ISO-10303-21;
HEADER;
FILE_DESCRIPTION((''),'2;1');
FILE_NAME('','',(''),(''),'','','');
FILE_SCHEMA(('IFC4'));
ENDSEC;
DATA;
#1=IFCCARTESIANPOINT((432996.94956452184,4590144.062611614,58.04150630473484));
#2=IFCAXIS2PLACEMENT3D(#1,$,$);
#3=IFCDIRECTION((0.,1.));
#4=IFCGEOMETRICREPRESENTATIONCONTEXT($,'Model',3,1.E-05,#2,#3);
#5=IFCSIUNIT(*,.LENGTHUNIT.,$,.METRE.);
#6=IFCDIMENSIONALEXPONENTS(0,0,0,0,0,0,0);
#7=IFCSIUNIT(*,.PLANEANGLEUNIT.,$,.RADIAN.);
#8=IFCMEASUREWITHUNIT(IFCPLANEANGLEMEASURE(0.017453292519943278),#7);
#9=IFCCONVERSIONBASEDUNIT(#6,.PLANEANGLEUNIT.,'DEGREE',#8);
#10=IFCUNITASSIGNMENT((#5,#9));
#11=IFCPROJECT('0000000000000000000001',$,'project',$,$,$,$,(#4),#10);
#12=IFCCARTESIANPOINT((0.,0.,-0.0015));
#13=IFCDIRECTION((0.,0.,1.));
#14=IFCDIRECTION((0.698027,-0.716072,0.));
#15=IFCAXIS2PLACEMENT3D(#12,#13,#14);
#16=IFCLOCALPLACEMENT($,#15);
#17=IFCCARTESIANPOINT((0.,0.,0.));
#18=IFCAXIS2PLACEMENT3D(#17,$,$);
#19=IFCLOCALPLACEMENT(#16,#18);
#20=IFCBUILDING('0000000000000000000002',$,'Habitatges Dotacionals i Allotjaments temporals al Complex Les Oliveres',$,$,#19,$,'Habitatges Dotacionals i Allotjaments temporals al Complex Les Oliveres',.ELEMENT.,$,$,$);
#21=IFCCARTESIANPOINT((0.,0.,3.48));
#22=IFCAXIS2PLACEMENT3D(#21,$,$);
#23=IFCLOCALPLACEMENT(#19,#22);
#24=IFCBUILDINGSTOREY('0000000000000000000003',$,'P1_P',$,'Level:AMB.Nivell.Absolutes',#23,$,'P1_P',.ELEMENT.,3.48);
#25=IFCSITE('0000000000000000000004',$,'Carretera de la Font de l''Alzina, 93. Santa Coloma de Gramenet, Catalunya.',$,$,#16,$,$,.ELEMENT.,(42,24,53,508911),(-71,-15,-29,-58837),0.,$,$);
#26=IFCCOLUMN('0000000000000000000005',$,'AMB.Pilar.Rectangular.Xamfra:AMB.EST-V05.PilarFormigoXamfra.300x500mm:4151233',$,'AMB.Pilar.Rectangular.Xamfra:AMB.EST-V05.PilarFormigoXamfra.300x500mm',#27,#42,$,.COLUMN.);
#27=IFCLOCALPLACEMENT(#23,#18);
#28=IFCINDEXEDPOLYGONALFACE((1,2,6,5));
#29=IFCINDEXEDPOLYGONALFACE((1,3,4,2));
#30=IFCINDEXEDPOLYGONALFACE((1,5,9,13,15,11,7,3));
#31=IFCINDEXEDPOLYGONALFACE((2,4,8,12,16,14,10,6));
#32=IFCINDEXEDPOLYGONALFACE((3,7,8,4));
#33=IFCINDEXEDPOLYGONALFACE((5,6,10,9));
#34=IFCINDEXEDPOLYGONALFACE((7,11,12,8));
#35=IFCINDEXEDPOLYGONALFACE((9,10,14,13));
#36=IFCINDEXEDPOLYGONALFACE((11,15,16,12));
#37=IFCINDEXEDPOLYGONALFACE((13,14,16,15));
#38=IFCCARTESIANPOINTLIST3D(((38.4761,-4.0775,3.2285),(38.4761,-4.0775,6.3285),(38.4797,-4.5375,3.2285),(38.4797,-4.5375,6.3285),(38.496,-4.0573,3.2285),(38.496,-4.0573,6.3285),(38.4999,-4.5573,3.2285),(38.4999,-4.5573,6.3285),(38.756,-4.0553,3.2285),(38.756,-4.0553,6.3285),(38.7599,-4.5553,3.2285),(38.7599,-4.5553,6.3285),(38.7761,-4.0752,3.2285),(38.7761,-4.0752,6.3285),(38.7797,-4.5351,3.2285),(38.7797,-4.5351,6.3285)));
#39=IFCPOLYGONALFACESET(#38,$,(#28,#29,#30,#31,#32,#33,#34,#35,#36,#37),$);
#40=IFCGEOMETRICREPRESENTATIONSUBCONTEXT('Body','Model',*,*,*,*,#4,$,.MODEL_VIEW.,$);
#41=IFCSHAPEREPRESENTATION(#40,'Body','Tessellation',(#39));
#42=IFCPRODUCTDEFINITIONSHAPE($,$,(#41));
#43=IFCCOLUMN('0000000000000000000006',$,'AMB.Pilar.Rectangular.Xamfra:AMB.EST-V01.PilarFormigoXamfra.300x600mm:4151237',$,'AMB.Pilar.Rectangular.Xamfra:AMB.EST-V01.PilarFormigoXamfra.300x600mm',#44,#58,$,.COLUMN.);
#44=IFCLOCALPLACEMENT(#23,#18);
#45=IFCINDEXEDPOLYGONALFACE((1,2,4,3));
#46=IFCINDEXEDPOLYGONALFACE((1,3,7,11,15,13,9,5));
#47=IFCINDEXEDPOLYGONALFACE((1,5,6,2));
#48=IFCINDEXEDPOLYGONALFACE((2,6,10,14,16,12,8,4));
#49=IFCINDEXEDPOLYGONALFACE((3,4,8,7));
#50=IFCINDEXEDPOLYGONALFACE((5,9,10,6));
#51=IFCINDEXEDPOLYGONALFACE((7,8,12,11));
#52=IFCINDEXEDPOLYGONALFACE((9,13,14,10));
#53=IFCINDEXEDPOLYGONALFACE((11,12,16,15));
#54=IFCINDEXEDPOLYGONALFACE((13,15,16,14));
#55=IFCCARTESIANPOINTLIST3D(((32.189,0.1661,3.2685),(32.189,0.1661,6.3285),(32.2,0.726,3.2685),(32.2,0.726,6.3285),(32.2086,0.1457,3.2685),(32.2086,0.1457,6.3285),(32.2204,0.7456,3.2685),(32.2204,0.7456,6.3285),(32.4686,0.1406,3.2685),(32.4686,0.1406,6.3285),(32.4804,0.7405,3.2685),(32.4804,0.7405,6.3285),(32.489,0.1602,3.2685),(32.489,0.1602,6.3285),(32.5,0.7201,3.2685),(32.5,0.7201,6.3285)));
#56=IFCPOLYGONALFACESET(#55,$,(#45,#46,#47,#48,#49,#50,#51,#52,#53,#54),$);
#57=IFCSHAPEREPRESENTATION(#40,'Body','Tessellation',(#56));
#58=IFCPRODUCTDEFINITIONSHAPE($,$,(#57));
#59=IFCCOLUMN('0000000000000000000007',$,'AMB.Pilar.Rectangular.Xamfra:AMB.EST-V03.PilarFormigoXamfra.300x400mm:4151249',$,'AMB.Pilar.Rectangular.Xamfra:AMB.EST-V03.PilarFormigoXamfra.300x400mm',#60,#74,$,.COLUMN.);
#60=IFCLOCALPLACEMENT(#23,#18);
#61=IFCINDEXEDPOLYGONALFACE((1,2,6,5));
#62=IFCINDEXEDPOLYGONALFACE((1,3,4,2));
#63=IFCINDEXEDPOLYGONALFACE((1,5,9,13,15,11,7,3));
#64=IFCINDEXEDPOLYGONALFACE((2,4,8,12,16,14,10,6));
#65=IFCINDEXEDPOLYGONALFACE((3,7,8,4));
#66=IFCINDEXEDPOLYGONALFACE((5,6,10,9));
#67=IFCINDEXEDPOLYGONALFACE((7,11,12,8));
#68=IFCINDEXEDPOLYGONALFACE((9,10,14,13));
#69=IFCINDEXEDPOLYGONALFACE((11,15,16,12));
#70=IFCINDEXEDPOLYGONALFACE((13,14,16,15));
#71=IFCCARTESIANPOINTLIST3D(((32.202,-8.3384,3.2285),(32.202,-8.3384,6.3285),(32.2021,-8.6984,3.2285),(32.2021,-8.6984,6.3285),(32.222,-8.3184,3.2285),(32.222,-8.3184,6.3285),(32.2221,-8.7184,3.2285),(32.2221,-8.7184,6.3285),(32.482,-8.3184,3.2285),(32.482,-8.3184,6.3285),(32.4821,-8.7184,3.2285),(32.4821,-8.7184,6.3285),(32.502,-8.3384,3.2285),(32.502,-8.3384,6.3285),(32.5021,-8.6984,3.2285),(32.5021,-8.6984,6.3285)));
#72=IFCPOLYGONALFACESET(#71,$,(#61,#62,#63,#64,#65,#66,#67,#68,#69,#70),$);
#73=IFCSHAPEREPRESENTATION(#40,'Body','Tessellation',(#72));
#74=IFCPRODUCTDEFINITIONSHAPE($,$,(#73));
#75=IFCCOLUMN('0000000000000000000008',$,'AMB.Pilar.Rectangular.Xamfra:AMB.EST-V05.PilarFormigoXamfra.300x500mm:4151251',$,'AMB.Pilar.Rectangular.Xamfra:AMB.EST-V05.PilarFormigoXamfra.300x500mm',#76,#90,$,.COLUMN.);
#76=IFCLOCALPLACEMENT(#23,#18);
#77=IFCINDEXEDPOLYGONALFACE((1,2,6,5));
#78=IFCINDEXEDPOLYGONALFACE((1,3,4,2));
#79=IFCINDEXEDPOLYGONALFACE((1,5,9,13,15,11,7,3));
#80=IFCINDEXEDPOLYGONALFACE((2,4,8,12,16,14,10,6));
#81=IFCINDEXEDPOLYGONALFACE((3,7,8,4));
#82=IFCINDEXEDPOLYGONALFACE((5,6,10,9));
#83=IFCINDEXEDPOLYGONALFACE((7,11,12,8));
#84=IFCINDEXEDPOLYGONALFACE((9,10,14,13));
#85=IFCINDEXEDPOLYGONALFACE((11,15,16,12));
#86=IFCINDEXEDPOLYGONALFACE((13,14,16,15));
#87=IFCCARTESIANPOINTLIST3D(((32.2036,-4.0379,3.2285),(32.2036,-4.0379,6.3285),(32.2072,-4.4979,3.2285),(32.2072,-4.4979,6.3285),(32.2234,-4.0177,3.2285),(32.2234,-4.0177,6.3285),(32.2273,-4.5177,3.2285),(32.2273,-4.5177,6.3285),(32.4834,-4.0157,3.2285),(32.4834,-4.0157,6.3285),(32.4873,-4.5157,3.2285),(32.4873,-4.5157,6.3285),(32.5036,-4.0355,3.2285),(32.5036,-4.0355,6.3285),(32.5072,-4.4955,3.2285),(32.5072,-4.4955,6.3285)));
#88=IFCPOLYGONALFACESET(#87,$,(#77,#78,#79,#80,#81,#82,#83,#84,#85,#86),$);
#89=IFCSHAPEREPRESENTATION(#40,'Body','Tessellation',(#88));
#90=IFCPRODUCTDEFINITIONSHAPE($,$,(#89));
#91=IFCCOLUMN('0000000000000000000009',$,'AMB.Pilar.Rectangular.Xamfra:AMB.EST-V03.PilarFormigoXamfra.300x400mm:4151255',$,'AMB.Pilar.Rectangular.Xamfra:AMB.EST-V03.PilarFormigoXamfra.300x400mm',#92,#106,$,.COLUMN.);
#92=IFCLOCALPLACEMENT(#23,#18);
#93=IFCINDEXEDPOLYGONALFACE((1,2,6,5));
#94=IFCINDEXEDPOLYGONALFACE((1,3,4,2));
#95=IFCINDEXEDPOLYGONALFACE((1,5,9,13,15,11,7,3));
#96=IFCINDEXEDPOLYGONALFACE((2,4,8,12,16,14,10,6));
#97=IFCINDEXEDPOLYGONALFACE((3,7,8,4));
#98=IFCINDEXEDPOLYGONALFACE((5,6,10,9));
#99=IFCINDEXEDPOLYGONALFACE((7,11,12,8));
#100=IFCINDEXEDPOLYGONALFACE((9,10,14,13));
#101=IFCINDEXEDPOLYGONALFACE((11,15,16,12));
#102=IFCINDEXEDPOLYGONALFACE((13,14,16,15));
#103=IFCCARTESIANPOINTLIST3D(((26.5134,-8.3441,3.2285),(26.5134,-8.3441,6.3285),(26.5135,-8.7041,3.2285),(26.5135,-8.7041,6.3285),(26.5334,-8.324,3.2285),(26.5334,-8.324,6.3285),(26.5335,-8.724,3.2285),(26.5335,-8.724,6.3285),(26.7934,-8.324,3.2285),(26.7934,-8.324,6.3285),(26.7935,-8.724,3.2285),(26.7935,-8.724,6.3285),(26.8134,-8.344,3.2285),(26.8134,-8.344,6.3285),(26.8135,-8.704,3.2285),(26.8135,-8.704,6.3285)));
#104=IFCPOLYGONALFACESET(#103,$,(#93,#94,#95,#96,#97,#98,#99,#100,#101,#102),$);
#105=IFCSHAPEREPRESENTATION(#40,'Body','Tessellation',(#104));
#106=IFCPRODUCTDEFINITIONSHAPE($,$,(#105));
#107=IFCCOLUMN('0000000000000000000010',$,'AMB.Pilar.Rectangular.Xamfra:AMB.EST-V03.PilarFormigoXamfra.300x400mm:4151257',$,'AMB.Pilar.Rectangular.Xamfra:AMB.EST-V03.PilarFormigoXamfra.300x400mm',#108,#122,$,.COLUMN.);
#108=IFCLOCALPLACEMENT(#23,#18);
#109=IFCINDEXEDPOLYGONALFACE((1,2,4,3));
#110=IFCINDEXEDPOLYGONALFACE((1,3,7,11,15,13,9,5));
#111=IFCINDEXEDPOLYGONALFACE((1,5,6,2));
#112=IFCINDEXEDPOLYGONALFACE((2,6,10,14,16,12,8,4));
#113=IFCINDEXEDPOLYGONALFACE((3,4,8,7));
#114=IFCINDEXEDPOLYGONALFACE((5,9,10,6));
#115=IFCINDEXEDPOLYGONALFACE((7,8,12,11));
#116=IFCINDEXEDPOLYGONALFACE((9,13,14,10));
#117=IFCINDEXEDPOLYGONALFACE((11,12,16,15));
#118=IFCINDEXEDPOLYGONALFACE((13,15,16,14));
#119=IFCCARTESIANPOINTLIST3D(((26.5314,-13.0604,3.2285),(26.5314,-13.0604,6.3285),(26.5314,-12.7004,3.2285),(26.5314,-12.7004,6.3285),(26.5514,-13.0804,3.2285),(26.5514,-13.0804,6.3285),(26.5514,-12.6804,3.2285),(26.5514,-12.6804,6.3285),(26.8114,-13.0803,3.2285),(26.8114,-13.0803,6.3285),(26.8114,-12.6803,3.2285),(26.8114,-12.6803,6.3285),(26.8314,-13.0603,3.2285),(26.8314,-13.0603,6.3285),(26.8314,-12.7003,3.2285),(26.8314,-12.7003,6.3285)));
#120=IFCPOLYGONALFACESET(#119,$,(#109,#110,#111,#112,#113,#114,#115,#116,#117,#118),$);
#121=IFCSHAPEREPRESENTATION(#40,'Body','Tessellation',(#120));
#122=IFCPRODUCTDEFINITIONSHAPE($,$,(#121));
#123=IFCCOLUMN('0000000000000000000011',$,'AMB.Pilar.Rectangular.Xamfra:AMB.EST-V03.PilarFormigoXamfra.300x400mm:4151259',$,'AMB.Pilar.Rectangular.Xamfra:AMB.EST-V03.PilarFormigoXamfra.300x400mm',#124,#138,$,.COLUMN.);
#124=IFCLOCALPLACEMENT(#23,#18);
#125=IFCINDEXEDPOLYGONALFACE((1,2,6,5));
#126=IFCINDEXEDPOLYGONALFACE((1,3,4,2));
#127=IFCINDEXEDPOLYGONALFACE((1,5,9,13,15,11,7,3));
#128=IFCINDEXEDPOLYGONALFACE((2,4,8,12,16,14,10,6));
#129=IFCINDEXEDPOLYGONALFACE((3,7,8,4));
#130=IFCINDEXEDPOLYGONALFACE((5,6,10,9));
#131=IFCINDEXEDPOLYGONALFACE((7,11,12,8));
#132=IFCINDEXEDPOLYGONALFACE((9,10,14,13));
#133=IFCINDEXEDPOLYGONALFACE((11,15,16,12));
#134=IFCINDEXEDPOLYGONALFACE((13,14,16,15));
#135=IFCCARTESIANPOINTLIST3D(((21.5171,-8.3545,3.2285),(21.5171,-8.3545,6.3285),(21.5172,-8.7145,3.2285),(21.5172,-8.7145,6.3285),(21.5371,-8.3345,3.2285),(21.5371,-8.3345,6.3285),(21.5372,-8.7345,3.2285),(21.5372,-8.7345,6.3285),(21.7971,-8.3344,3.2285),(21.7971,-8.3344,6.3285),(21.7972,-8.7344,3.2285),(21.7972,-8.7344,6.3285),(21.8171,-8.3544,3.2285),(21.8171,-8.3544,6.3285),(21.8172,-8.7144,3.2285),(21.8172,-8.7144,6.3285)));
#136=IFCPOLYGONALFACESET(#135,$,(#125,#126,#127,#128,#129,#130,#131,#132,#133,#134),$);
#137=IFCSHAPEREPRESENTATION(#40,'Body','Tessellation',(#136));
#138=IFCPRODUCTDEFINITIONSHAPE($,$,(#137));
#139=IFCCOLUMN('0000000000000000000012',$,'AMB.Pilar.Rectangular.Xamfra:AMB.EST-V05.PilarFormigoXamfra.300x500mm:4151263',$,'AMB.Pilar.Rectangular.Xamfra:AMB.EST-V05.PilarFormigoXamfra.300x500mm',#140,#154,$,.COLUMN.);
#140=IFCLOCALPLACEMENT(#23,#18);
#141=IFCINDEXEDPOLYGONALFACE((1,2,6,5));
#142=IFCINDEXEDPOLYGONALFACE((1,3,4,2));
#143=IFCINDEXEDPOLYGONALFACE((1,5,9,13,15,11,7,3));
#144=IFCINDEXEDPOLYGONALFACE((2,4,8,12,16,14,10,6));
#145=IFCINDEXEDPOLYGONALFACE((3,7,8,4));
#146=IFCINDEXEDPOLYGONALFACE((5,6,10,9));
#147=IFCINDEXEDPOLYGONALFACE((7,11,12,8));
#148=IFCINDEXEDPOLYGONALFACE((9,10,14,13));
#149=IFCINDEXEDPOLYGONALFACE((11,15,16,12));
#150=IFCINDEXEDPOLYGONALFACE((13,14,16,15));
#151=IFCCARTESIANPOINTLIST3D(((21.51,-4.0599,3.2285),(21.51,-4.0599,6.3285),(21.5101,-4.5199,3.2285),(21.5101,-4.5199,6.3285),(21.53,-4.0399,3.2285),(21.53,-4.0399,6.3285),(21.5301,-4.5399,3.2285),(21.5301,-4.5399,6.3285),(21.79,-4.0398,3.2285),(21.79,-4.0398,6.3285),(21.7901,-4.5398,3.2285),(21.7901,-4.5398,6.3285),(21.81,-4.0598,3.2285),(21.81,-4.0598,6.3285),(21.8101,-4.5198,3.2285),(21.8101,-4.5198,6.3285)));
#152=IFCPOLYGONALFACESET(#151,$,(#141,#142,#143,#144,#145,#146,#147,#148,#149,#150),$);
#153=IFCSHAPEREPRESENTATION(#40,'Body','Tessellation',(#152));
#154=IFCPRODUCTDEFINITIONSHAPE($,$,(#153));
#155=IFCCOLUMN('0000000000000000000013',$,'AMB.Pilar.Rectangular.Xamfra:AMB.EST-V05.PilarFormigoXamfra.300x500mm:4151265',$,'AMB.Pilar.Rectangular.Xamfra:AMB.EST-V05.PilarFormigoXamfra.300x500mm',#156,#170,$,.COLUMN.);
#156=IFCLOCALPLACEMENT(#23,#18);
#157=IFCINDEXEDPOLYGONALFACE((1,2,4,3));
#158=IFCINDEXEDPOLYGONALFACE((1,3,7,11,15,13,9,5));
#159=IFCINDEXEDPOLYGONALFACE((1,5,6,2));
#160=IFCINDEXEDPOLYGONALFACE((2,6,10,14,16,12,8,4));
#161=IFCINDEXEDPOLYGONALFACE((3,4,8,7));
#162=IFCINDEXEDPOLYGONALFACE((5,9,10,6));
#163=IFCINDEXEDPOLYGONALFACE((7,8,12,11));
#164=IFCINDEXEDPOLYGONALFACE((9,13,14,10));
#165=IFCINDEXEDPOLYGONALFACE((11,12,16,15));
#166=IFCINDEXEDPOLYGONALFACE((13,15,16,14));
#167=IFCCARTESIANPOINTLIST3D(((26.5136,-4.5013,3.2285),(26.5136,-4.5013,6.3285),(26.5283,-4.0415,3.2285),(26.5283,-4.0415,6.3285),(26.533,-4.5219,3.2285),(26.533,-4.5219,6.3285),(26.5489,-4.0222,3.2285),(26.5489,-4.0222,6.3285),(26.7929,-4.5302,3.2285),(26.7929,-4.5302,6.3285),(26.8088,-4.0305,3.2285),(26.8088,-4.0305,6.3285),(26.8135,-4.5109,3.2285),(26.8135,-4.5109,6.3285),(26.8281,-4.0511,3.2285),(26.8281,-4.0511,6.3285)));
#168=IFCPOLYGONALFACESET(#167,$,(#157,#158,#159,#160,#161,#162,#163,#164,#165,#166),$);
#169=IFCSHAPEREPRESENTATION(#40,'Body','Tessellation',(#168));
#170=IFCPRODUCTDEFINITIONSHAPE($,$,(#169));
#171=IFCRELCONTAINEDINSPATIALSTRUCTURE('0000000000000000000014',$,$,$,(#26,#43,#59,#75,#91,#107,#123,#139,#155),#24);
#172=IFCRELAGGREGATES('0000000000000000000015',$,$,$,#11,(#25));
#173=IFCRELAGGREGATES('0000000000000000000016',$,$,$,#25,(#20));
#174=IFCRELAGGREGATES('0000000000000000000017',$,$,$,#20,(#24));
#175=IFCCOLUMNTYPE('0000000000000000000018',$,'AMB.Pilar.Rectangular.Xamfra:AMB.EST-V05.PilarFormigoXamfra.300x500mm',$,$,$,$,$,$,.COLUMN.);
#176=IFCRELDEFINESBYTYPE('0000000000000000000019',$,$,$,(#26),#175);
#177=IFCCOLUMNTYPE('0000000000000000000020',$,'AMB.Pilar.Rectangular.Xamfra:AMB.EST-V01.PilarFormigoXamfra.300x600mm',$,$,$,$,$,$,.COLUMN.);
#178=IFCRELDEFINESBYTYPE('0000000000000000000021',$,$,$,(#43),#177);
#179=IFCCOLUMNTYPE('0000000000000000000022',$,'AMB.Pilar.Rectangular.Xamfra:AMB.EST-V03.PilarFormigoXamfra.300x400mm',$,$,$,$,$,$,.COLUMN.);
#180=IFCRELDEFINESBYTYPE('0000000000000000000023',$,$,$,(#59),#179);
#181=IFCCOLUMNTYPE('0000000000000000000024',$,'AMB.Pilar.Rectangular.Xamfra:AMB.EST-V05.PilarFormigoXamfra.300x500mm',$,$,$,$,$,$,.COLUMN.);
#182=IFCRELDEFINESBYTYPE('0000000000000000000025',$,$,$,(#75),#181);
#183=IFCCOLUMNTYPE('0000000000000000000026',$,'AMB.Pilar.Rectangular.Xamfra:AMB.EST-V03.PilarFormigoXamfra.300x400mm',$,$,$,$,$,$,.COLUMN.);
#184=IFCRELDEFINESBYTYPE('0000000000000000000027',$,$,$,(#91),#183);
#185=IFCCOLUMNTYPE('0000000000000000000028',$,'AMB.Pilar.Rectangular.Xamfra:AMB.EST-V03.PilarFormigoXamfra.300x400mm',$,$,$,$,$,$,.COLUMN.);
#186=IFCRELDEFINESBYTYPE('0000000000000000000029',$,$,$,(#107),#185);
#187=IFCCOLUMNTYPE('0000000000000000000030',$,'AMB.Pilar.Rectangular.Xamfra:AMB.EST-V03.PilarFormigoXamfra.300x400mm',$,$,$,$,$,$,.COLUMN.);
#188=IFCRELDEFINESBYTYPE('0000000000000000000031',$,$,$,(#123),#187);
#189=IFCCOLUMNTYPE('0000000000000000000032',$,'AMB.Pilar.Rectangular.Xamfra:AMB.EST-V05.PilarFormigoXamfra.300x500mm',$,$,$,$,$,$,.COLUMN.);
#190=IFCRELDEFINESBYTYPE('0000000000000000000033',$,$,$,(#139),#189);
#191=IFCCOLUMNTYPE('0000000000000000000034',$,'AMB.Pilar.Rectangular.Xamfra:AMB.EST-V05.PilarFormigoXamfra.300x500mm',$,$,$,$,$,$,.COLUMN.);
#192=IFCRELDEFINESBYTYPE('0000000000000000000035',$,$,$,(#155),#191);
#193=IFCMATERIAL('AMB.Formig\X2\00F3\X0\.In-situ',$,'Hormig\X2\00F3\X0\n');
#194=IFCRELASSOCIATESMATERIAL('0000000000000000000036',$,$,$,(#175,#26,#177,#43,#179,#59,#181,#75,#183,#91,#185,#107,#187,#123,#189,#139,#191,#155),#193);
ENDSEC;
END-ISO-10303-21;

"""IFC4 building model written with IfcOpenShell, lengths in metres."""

from ifc_helpers import new_model, entity, si_unit, converted_unit, direction, frame, origin, place, context, subcontext, project, spatial, indexed_curve, outline, extrude, source, transform, mapped, material, type_object, type_shapes, element, save


model = new_model("IFC4")

# Units and contexts
model_context = context("Model", 3, precision=1e-05, world=frame((432996.94956452184, 4590144.062611614, 58.04150630473484)), true_north=direction((0.0, 1.0)))
body_context = subcontext(model_context, "Body", "Model", "MODEL_VIEW")
ifc_project = project(units=[si_unit("LENGTHUNIT", "METRE"), converted_unit("PLANEANGLEUNIT", "DEGREE", entity("IfcPlaneAngleMeasure", 0.017453292519943278), si_unit("PLANEANGLEUNIT", "RADIAN"), dimensions=[0, 0, 0, 0, 0, 0, 0])], contexts=[model_context])

# Site, building, storey
site_placement = place(None, frame((0.0, 0.0, -0.0015), z_axis=(0.0, 0.0, 1.0), x_axis=(0.698027, -0.716072, 0.0)))
site = spatial("IfcSite", under=ifc_project, at=site_placement, Name="Carretera de la Font de l'Alzina, 93. Santa Coloma de Gramenet, Catalunya.", CompositionType="ELEMENT", RefLatitude=(42, 24, 53, 508911), RefLongitude=(-71, -15, -29, -58837), RefElevation=0.0)
building_placement = place(site_placement, origin())
building = spatial("IfcBuilding", under=site, at=building_placement, Name="Habitatges Dotacionals i Allotjaments temporals al Complex Les Oliveres", LongName="Habitatges Dotacionals i Allotjaments temporals al Complex Les Oliveres", CompositionType="ELEMENT")
storey_placement = place(building_placement, frame((0.0, 0.0, 3.48)))
storey = spatial("IfcBuildingStorey", under=building, at=storey_placement, Name="P1_P", ObjectType="Level:AMB.Nivell.Absolutes", LongName="P1_P", CompositionType="ELEMENT", Elevation=3.48)

# Columns
ifc_material = material(Name="AMB.Formigó.In-situ", Category="Hormigón")
column_type_1 = type_object("IfcColumnType", Name="AMB.Pilar.Rectangular.Xamfra:AMB.EST-V05.PilarFormigoXamfra.300x500mm", PredefinedType="COLUMN", material=ifc_material)
shared_shape_1 = source(origin(), body_context, "Body", "SweptSolid", [
    extrude(outline(indexed_curve([(-0.13, -0.25), (0.13, -0.25), (0.15, -0.23), (0.15, 0.23), (0.13, 0.25), (-0.13, 0.25), (-0.15, 0.23), (-0.15, -0.23), (-0.13, -0.25)], self_intersect=False)), frame((38.6279, -4.3063, 6.7085), z_axis=(0.0, 0.0, 1.0), x_axis=(-0.99997, -0.007796, 0.0)), (0.0, 0.0, 1.0), 3.1),
])
type_shapes(column_type_1, [shared_shape_1])
column_1_placement = place(storey_placement, frame((0.0, 0.0, -3.48)))
element("IfcColumn", 1, at=column_1_placement, inside=storey, type_object=column_type_1, material=ifc_material, Name="AMB.Pilar.Rectangular.Xamfra:AMB.EST-V05.PilarFormigoXamfra.300x500mm:4151233", ObjectType="AMB.Pilar.Rectangular.Xamfra:AMB.EST-V05.PilarFormigoXamfra.300x500mm", PredefinedType="COLUMN", context=body_context, shape_type="MappedRepresentation", body=[
    mapped(shared_shape_1, transform((0.0, 0.0, 0.0), scale=1.0)),
])
column_type_2 = type_object("IfcColumnType", Name="AMB.Pilar.Rectangular.Xamfra:AMB.EST-V01.PilarFormigoXamfra.300x600mm", PredefinedType="COLUMN", material=ifc_material)
shared_shape_2 = source(origin(), body_context, "Body", "SweptSolid", [
    extrude(outline(indexed_curve([(-0.13, -0.3), (0.13, -0.3), (0.15, -0.28), (0.15, 0.28), (0.13, 0.3), (-0.13, 0.3), (-0.15, 0.28), (-0.15, -0.28), (-0.13, -0.3)], self_intersect=False)), frame((32.3445, 0.4431, 6.7485), z_axis=(0.0, 0.0, 1.0), x_axis=(-0.999807, 0.019634, 0.0)), (0.0, 0.0, 1.0), 3.06),
])
type_shapes(column_type_2, [shared_shape_2])
column_2_placement = place(storey_placement, frame((0.0, 0.0, -3.48)))
element("IfcColumn", 2, at=column_2_placement, inside=storey, type_object=column_type_2, material=ifc_material, Name="AMB.Pilar.Rectangular.Xamfra:AMB.EST-V01.PilarFormigoXamfra.300x600mm:4151237", ObjectType="AMB.Pilar.Rectangular.Xamfra:AMB.EST-V01.PilarFormigoXamfra.300x600mm", PredefinedType="COLUMN", context=body_context, shape_type="MappedRepresentation", body=[
    mapped(shared_shape_2, transform((0.0, 0.0, 0.0), scale=1.0)),
])
column_type_3 = type_object("IfcColumnType", Name="AMB.Pilar.Rectangular.Xamfra:AMB.EST-V03.PilarFormigoXamfra.300x400mm", PredefinedType="COLUMN", material=ifc_material)
shared_shape_3 = source(origin(), body_context, "Body", "SweptSolid", [
    extrude(outline(indexed_curve([(-0.13, -0.2), (0.13, -0.2), (0.15, -0.18), (0.15, 0.18), (0.13, 0.2), (-0.13, 0.2), (-0.15, 0.18), (-0.15, -0.18), (-0.13, -0.2)], self_intersect=False)), frame((32.3521, -8.5184, 6.7085), z_axis=(0.0, 0.0, 1.0), x_axis=(1.0, 0.000195, 0.0)), (0.0, 0.0, 1.0), 3.1),
])
type_shapes(column_type_3, [shared_shape_3])
column_3_placement = place(storey_placement, frame((0.0, 0.0, -3.48)))
element("IfcColumn", 3, at=column_3_placement, inside=storey, type_object=column_type_3, material=ifc_material, Name="AMB.Pilar.Rectangular.Xamfra:AMB.EST-V03.PilarFormigoXamfra.300x400mm:4151249", ObjectType="AMB.Pilar.Rectangular.Xamfra:AMB.EST-V03.PilarFormigoXamfra.300x400mm", PredefinedType="COLUMN", context=body_context, shape_type="MappedRepresentation", body=[
    mapped(shared_shape_3, transform((0.0, 0.0, 0.0), scale=1.0)),
])
column_type_4 = type_object("IfcColumnType", Name="AMB.Pilar.Rectangular.Xamfra:AMB.EST-V05.PilarFormigoXamfra.300x500mm", PredefinedType="COLUMN", material=ifc_material)
shared_shape_4 = source(origin(), body_context, "Body", "SweptSolid", [
    extrude(outline(indexed_curve([(-0.13, -0.25), (0.13, -0.25), (0.15, -0.23), (0.15, 0.23), (0.13, 0.25), (-0.13, 0.25), (-0.15, 0.23), (-0.15, -0.23), (-0.13, -0.25)], self_intersect=False)), frame((32.3554, -4.2667, 6.7085), z_axis=(0.0, 0.0, 1.0), x_axis=(-0.99997, -0.007796, 0.0)), (0.0, 0.0, 1.0), 3.1),
])
type_shapes(column_type_4, [shared_shape_4])
column_4_placement = place(storey_placement, frame((0.0, 0.0, -3.48)))
element("IfcColumn", 4, at=column_4_placement, inside=storey, type_object=column_type_4, material=ifc_material, Name="AMB.Pilar.Rectangular.Xamfra:AMB.EST-V05.PilarFormigoXamfra.300x500mm:4151251", ObjectType="AMB.Pilar.Rectangular.Xamfra:AMB.EST-V05.PilarFormigoXamfra.300x500mm", PredefinedType="COLUMN", context=body_context, shape_type="MappedRepresentation", body=[
    mapped(shared_shape_4, transform((0.0, 0.0, 0.0), scale=1.0)),
])
column_type_5 = type_object("IfcColumnType", Name="AMB.Pilar.Rectangular.Xamfra:AMB.EST-V03.PilarFormigoXamfra.300x400mm", PredefinedType="COLUMN", material=ifc_material)
shared_shape_5 = source(origin(), body_context, "Body", "SweptSolid", [
    extrude(outline(indexed_curve([(-0.13, -0.2), (0.13, -0.2), (0.15, -0.18), (0.15, 0.18), (0.13, 0.2), (-0.13, 0.2), (-0.15, 0.18), (-0.15, -0.18), (-0.13, -0.2)], self_intersect=False)), frame((26.6635, -8.524, 6.7085), z_axis=(0.0, 0.0, 1.0), x_axis=(1.0, 0.000195, 0.0)), (0.0, 0.0, 1.0), 3.1),
])
type_shapes(column_type_5, [shared_shape_5])
column_5_placement = place(storey_placement, frame((0.0, 0.0, -3.48)))
element("IfcColumn", 5, at=column_5_placement, inside=storey, type_object=column_type_5, material=ifc_material, Name="AMB.Pilar.Rectangular.Xamfra:AMB.EST-V03.PilarFormigoXamfra.300x400mm:4151255", ObjectType="AMB.Pilar.Rectangular.Xamfra:AMB.EST-V03.PilarFormigoXamfra.300x400mm", PredefinedType="COLUMN", context=body_context, shape_type="MappedRepresentation", body=[
    mapped(shared_shape_5, transform((0.0, 0.0, 0.0), scale=1.0)),
])
column_type_6 = type_object("IfcColumnType", Name="AMB.Pilar.Rectangular.Xamfra:AMB.EST-V03.PilarFormigoXamfra.300x400mm", PredefinedType="COLUMN", material=ifc_material)
shared_shape_6 = source(origin(), body_context, "Body", "SweptSolid", [
    extrude(outline(indexed_curve([(-0.13, -0.2), (0.13, -0.2), (0.15, -0.18), (0.15, 0.18), (0.13, 0.2), (-0.13, 0.2), (-0.15, 0.18), (-0.15, -0.18), (-0.13, -0.2)], self_intersect=False)), frame((26.6814, -12.8804, 6.7085), z_axis=(0.0, 0.0, 1.0), x_axis=(1.0, 0.000195, 0.0)), (0.0, 0.0, 1.0), 3.1),
])
type_shapes(column_type_6, [shared_shape_6])
column_6_placement = place(storey_placement, frame((0.0, 0.0, -3.48)))
element("IfcColumn", 6, at=column_6_placement, inside=storey, type_object=column_type_6, material=ifc_material, Name="AMB.Pilar.Rectangular.Xamfra:AMB.EST-V03.PilarFormigoXamfra.300x400mm:4151257", ObjectType="AMB.Pilar.Rectangular.Xamfra:AMB.EST-V03.PilarFormigoXamfra.300x400mm", PredefinedType="COLUMN", context=body_context, shape_type="MappedRepresentation", body=[
    mapped(shared_shape_6, transform((0.0, 0.0, 0.0), scale=1.0)),
])
column_type_7 = type_object("IfcColumnType", Name="AMB.Pilar.Rectangular.Xamfra:AMB.EST-V03.PilarFormigoXamfra.300x400mm", PredefinedType="COLUMN", material=ifc_material)
shared_shape_7 = source(origin(), body_context, "Body", "SweptSolid", [
    extrude(outline(indexed_curve([(-0.13, -0.2), (0.13, -0.2), (0.15, -0.18), (0.15, 0.18), (0.13, 0.2), (-0.13, 0.2), (-0.15, 0.18), (-0.15, -0.18), (-0.13, -0.2)], self_intersect=False)), frame((21.6672, -8.5344, 6.7085), z_axis=(0.0, 0.0, 1.0), x_axis=(1.0, 0.000195, 0.0)), (0.0, 0.0, 1.0), 3.1),
])
type_shapes(column_type_7, [shared_shape_7])
column_7_placement = place(storey_placement, frame((0.0, 0.0, -3.48)))
element("IfcColumn", 7, at=column_7_placement, inside=storey, type_object=column_type_7, material=ifc_material, Name="AMB.Pilar.Rectangular.Xamfra:AMB.EST-V03.PilarFormigoXamfra.300x400mm:4151259", ObjectType="AMB.Pilar.Rectangular.Xamfra:AMB.EST-V03.PilarFormigoXamfra.300x400mm", PredefinedType="COLUMN", context=body_context, shape_type="MappedRepresentation", body=[
    mapped(shared_shape_7, transform((0.0, 0.0, 0.0), scale=1.0)),
])
column_type_8 = type_object("IfcColumnType", Name="AMB.Pilar.Rectangular.Xamfra:AMB.EST-V05.PilarFormigoXamfra.300x500mm", PredefinedType="COLUMN", material=ifc_material)
shared_shape_8 = source(origin(), body_context, "Body", "SweptSolid", [
    extrude(outline(indexed_curve([(-0.13, -0.25), (0.13, -0.25), (0.15, -0.23), (0.15, 0.23), (0.13, 0.25), (-0.13, 0.25), (-0.15, 0.23), (-0.15, -0.23), (-0.13, -0.25)], self_intersect=False)), frame((21.6601, -4.2898, 6.7085), z_axis=(0.0, 0.0, 1.0), x_axis=(1.0, 0.000195, 0.0)), (0.0, 0.0, 1.0), 3.1),
])
type_shapes(column_type_8, [shared_shape_8])
column_8_placement = place(storey_placement, frame((0.0, 0.0, -3.48)))
element("IfcColumn", 8, at=column_8_placement, inside=storey, type_object=column_type_8, material=ifc_material, Name="AMB.Pilar.Rectangular.Xamfra:AMB.EST-V05.PilarFormigoXamfra.300x500mm:4151263", ObjectType="AMB.Pilar.Rectangular.Xamfra:AMB.EST-V05.PilarFormigoXamfra.300x500mm", PredefinedType="COLUMN", context=body_context, shape_type="MappedRepresentation", body=[
    mapped(shared_shape_8, transform((0.0, 0.0, 0.0), scale=1.0)),
])
column_type_9 = type_object("IfcColumnType", Name="AMB.Pilar.Rectangular.Xamfra:AMB.EST-V05.PilarFormigoXamfra.300x500mm", PredefinedType="COLUMN", material=ifc_material)
shared_shape_9 = source(origin(), body_context, "Body", "SweptSolid", [
    extrude(outline(indexed_curve([(-0.13, -0.25), (0.13, -0.25), (0.15, -0.23), (0.15, 0.23), (0.13, 0.25), (-0.13, 0.25), (-0.15, 0.23), (-0.15, -0.23), (-0.13, -0.25)], self_intersect=False)), frame((26.6709, -4.2762, 6.7085), z_axis=(0.0, 0.0, 1.0), x_axis=(0.999493, -0.031826, 0.0)), (0.0, 0.0, 1.0), 3.1),
])
type_shapes(column_type_9, [shared_shape_9])
column_9_placement = place(storey_placement, frame((0.0, 0.0, -3.48)))
element("IfcColumn", 9, at=column_9_placement, inside=storey, type_object=column_type_9, material=ifc_material, Name="AMB.Pilar.Rectangular.Xamfra:AMB.EST-V05.PilarFormigoXamfra.300x500mm:4151265", ObjectType="AMB.Pilar.Rectangular.Xamfra:AMB.EST-V05.PilarFormigoXamfra.300x500mm", PredefinedType="COLUMN", context=body_context, shape_type="MappedRepresentation", body=[
    mapped(shared_shape_9, transform((0.0, 0.0, 0.0), scale=1.0)),
])

save(model, "model.ifc")
